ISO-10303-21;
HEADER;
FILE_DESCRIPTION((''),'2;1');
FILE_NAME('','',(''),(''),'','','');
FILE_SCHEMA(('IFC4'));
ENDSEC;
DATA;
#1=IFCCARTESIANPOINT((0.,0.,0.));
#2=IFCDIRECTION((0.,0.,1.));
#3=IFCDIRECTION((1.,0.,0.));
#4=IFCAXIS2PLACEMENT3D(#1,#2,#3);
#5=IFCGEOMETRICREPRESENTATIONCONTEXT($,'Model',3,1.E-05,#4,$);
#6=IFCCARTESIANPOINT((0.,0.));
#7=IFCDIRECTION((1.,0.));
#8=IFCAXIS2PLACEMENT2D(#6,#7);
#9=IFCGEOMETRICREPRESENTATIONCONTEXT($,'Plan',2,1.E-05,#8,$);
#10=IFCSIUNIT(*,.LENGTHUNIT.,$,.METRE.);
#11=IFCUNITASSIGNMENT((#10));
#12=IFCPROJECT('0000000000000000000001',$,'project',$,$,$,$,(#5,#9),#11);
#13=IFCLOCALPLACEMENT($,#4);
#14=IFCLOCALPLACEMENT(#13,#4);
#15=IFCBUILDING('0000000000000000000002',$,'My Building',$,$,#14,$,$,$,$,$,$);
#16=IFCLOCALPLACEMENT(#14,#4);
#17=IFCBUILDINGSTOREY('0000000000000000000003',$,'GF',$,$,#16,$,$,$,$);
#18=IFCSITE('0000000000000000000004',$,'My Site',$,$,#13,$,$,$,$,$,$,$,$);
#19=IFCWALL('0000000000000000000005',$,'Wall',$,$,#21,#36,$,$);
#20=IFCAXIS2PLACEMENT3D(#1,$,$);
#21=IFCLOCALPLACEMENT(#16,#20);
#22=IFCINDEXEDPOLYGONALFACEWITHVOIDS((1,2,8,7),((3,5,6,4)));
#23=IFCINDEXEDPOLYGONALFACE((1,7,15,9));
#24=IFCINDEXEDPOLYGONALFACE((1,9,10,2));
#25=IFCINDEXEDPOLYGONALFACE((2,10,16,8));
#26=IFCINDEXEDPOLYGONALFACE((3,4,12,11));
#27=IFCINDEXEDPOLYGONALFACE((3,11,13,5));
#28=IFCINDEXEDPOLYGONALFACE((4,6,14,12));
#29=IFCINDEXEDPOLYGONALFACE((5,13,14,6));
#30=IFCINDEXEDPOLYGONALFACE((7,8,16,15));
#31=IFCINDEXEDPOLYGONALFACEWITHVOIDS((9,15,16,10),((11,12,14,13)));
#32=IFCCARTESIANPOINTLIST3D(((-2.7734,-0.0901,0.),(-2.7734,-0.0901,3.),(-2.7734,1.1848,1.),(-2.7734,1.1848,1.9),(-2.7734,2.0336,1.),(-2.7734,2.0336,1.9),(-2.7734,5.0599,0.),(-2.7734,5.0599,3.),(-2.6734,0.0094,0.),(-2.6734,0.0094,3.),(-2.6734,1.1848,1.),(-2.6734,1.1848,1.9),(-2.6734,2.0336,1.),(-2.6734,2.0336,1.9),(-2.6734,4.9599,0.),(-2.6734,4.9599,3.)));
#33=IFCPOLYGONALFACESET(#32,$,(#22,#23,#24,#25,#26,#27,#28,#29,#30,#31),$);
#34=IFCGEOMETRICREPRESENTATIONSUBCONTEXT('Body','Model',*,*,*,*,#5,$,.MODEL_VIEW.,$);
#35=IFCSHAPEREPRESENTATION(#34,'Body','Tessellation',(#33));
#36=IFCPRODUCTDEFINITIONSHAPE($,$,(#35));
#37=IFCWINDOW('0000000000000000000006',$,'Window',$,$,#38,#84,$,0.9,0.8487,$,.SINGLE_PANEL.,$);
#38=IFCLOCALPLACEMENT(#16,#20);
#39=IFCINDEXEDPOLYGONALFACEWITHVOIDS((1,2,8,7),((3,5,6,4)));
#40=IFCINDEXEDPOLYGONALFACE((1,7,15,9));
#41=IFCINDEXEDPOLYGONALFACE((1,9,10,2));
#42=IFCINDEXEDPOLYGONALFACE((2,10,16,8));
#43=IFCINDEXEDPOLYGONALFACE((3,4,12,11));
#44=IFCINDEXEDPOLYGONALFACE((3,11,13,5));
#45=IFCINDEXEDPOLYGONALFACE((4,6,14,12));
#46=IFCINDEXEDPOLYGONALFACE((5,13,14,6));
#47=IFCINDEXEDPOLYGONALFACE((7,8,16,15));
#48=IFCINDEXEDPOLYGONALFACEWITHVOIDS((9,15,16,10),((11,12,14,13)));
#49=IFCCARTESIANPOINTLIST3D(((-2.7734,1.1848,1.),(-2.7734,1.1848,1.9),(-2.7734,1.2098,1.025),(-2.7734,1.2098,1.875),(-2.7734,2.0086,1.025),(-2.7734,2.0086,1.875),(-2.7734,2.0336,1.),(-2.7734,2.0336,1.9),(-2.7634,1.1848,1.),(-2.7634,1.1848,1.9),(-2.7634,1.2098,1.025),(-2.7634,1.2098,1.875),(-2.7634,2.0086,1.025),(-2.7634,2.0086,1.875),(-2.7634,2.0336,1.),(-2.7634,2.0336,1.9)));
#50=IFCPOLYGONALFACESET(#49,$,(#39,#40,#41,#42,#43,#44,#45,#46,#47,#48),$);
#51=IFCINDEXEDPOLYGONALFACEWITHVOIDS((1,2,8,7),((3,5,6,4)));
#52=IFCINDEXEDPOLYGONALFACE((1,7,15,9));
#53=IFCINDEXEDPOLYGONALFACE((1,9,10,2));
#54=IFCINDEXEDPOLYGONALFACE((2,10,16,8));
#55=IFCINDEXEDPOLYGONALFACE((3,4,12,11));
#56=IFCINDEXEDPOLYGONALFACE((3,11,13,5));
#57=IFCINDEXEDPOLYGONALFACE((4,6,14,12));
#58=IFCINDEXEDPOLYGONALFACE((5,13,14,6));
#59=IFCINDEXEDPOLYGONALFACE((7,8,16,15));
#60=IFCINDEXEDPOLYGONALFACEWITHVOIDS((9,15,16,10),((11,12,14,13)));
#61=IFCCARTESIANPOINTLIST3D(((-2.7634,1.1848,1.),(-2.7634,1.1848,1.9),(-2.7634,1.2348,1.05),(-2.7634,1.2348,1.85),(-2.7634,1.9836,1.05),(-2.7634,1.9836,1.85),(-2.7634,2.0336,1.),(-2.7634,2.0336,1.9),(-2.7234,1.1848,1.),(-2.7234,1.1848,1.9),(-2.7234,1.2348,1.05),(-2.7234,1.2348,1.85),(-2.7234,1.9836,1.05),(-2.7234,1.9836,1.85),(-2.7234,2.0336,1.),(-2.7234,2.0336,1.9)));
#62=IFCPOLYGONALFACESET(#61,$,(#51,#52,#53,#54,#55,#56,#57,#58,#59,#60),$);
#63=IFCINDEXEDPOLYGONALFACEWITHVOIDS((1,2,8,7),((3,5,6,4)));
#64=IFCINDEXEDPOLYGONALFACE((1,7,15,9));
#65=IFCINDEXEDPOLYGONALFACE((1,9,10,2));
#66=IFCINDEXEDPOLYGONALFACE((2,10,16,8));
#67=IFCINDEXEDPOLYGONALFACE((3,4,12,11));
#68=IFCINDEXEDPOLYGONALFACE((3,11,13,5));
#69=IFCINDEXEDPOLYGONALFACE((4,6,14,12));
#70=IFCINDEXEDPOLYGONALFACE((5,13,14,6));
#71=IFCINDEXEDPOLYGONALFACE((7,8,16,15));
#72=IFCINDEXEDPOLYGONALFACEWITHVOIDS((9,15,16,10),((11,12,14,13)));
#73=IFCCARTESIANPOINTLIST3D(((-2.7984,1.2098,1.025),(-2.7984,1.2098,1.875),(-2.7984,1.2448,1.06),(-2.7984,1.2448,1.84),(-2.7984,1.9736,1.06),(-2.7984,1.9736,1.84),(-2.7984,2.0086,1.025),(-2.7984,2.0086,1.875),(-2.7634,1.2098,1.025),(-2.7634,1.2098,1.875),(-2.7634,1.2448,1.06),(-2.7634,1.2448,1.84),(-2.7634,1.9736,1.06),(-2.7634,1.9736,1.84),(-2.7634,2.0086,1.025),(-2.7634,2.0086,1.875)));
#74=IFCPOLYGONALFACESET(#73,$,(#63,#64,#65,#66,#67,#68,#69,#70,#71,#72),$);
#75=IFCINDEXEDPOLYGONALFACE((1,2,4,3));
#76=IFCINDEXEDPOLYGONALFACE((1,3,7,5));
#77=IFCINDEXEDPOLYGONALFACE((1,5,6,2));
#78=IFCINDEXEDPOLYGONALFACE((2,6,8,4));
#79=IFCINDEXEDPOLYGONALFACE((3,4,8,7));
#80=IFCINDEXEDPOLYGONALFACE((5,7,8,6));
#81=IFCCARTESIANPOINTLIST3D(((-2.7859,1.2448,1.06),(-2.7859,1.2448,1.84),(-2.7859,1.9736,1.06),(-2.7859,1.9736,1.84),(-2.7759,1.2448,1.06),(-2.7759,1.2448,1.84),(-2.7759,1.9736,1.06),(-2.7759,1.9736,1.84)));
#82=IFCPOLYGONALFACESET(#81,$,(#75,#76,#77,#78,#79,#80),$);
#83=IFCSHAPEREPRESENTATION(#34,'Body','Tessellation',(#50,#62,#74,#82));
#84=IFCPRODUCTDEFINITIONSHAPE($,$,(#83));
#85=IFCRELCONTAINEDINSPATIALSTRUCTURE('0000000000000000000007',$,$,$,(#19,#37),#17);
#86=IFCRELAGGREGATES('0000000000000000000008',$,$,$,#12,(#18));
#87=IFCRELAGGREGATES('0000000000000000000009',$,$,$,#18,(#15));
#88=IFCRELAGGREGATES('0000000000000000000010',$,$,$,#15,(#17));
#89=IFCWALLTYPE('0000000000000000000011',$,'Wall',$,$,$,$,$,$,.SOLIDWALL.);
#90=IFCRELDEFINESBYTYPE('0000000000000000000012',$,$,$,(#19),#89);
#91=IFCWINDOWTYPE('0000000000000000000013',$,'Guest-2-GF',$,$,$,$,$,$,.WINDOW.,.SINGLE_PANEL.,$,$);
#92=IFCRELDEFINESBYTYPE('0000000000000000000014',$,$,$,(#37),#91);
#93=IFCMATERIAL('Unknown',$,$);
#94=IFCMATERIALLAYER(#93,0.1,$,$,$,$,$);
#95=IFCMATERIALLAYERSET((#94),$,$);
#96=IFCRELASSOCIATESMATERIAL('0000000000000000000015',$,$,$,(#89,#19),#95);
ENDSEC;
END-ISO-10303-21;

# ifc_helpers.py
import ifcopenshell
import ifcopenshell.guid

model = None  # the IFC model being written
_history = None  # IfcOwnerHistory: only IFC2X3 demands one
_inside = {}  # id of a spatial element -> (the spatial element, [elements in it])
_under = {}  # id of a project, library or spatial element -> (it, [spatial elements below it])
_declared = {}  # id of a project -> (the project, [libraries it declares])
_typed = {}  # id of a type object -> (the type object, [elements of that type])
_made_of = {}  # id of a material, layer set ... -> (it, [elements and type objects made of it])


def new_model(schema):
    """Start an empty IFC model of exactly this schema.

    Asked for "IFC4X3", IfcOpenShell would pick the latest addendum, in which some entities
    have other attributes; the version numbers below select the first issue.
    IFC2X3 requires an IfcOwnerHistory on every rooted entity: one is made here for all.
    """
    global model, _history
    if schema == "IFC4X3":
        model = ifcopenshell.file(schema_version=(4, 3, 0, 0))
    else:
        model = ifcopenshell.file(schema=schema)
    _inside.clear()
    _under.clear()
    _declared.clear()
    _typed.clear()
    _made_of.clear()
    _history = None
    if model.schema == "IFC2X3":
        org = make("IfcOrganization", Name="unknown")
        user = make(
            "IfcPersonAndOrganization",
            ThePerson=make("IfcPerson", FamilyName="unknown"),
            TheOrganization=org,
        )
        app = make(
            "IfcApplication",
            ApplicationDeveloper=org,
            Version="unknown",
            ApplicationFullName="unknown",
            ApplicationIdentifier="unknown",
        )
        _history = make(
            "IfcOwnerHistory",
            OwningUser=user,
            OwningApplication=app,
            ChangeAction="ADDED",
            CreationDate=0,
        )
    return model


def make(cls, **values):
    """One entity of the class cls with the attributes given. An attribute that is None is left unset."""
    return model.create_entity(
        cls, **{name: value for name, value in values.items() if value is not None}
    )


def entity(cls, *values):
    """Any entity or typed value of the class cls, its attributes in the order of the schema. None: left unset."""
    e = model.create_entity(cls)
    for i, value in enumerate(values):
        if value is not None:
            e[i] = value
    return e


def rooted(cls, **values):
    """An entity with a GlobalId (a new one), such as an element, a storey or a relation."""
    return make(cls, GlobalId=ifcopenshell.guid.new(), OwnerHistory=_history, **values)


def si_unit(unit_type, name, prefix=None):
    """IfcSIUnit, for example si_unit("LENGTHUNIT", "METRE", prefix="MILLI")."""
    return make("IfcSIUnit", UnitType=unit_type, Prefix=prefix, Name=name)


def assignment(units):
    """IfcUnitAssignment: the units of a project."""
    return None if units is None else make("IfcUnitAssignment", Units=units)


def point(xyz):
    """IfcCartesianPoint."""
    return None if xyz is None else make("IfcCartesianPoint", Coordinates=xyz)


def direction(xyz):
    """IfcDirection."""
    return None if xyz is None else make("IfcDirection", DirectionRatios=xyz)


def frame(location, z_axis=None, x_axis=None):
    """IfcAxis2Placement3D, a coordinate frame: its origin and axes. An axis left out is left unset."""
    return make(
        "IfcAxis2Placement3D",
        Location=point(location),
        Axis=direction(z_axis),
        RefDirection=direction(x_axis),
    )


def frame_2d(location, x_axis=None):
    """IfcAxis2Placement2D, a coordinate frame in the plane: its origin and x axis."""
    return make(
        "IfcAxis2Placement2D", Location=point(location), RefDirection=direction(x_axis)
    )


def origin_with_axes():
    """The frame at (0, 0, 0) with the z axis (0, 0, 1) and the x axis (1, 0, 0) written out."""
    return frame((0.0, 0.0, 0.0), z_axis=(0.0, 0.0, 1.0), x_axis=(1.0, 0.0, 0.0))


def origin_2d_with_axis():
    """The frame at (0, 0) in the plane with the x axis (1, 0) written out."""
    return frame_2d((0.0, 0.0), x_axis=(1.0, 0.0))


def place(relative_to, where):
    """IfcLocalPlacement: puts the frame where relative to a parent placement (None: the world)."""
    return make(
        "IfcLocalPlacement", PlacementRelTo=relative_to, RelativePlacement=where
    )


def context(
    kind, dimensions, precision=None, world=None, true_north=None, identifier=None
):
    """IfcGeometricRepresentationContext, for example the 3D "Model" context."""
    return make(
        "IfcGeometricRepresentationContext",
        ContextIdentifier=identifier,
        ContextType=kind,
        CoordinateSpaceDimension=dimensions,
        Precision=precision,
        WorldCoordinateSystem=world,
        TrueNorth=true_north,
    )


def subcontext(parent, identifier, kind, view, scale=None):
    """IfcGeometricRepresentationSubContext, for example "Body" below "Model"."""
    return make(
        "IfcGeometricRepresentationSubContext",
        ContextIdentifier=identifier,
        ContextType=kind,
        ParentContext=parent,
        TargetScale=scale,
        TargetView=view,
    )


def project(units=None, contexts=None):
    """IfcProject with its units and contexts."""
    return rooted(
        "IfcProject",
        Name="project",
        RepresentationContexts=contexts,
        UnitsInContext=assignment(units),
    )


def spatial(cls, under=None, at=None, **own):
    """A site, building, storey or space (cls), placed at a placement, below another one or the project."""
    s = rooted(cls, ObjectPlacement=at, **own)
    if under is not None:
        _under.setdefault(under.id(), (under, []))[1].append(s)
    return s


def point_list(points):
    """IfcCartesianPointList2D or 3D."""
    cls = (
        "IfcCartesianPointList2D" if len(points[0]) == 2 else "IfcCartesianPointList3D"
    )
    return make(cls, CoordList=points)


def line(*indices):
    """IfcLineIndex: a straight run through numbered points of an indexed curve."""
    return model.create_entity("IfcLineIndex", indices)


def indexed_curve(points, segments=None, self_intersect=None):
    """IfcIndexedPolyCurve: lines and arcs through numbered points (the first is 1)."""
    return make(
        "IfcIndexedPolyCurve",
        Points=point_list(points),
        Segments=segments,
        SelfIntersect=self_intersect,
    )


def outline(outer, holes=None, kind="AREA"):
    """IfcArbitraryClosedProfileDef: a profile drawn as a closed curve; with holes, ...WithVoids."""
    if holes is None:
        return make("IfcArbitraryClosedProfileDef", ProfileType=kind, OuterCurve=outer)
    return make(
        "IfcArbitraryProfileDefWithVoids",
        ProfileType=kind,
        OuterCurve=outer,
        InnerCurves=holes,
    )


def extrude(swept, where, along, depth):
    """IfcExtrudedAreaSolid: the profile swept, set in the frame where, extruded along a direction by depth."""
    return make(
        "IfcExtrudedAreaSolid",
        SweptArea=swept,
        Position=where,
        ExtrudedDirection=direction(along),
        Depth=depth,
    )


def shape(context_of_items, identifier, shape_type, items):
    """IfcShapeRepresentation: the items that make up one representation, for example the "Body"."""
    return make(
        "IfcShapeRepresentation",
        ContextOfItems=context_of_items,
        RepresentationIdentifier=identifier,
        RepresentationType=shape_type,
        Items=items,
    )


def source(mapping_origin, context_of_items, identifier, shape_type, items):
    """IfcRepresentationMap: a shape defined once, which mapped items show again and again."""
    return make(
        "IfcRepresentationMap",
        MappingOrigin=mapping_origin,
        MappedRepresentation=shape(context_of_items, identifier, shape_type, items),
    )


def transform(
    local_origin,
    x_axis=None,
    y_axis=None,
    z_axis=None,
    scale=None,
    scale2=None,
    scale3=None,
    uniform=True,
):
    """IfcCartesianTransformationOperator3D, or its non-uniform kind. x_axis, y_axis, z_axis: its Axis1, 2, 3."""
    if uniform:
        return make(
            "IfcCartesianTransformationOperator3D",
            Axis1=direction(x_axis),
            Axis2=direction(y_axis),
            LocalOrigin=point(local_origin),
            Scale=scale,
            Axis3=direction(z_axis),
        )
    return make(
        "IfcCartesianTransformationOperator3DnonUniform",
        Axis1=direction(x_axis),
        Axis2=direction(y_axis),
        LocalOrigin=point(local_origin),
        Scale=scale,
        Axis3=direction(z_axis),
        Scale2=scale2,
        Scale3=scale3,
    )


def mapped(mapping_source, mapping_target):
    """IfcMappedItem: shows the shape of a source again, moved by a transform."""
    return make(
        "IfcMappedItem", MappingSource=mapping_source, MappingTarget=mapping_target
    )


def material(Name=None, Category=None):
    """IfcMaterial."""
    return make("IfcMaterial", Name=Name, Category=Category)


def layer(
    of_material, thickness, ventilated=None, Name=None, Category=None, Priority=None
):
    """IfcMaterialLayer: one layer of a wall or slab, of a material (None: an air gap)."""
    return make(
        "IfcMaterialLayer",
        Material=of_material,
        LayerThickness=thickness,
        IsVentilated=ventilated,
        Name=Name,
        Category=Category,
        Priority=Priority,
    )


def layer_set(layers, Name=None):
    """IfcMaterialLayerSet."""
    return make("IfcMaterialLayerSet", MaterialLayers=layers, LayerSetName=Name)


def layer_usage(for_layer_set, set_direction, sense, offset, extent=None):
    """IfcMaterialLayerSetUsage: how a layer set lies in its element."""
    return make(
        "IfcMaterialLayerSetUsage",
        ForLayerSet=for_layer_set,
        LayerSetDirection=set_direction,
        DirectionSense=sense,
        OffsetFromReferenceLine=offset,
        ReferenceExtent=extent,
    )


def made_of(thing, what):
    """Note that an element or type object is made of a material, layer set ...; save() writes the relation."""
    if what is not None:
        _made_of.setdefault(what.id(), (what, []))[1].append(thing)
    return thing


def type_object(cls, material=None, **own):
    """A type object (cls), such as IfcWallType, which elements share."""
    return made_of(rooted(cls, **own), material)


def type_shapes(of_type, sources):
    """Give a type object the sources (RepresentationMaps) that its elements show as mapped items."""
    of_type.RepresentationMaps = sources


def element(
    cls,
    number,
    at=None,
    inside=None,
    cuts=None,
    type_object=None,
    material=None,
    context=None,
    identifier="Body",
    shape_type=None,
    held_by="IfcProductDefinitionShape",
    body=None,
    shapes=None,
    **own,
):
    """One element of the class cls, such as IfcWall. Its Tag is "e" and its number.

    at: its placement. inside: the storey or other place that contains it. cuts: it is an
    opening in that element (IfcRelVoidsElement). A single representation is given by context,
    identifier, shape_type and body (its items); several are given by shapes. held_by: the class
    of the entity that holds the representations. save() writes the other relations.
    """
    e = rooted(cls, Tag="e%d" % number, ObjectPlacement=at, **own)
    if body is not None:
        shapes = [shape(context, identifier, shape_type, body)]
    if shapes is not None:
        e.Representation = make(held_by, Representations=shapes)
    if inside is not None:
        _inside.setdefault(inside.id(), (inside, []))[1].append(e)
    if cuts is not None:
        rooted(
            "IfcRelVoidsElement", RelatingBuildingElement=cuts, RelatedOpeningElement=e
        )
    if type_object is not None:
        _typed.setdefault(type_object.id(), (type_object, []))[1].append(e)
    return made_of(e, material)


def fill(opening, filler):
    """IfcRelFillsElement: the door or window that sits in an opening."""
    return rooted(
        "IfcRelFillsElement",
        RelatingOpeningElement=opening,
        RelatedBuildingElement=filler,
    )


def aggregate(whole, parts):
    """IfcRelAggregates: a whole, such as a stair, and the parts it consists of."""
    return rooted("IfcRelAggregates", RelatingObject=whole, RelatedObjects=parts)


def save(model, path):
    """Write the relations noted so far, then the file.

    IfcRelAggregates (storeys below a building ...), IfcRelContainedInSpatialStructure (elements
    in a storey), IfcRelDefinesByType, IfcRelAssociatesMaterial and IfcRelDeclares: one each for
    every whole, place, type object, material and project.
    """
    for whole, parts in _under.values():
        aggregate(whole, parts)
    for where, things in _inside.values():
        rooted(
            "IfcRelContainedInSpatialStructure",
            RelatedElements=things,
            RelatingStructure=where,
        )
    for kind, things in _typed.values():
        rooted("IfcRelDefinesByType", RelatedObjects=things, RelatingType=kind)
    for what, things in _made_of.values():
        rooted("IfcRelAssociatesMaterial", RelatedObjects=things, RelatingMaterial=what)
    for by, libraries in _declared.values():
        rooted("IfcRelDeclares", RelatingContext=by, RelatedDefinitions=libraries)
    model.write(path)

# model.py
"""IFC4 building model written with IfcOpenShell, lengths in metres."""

from ifc_helpers import new_model, entity, si_unit, frame, origin_with_axes, origin_2d_with_axis, place, context, subcontext, project, spatial, line, indexed_curve, outline, extrude, shape, source, transform, mapped, material, layer, layer_set, layer_usage, type_object, type_shapes, element, fill, save


model = new_model("IFC4")

# Units and contexts
model_context = context("Model", 3, precision=1e-05, world=origin_with_axes())
plan_context = context("Plan", 2, precision=1e-05, world=origin_2d_with_axis())
body_context_1 = subcontext(model_context, "Body", "Model", "MODEL_VIEW")
body_context_2 = subcontext(plan_context, "Body", "Plan", "PLAN_VIEW")
ifc_project = project(units=[si_unit("LENGTHUNIT", "METRE")], contexts=[model_context, plan_context])

# Site, building, storey
site_placement = place(None, origin_with_axes())
site = spatial("IfcSite", under=ifc_project, at=site_placement, Name="My Site")
building_placement = place(site_placement, origin_with_axes())
building = spatial("IfcBuilding", under=site, at=building_placement, Name="My Building")
storey_placement = place(building_placement, origin_with_axes())
storey = spatial("IfcBuildingStorey", under=building, at=storey_placement, Name="GF")

# Shared definitions
ifc_material_1 = material(Name="Unknown")

# Shared definitions
ifc_layer_1 = layer(ifc_material_1, 0.1)
ifc_layer_set_1 = layer_set([ifc_layer_1])
wall_type = type_object("IfcWallType", Name="Wall", PredefinedType="SOLIDWALL", material=ifc_layer_set_1)

# Wall, opening, window
ifc_layer_usage_1 = layer_usage(ifc_layer_set_1, "AXIS2", "POSITIVE", 0.0)
wall_1_placement = place(storey_placement, frame((-2.7734, 5.0599, 0.0), z_axis=(0.0, 0.0, 1.0), x_axis=(0.0, -1.0, 0.0)))
wall_1 = element("IfcWall", 1, at=wall_1_placement, inside=storey, type_object=wall_type, material=ifc_layer_usage_1, Name="Wall", context=body_context_1, shape_type="SweptSolid", body=[
    extrude(outline(indexed_curve([(0.0, 0.0), (0.1, 0.1), (5.0504, 0.1), (5.15, 0.0)], segments=[line(1, 2, 3, 4, 1)])), origin_with_axes(), (0.0, 0.0, 1.0), 3.0),
])
shared_shape_1 = source(origin_with_axes(), body_context_1, "Body", "SweptSolid", [
    extrude(outline(indexed_curve([(0.0, 0.0), (0.8487, 0.0), (0.8487, 0.9), (0.0, 0.9)], segments=[line(1, 2, 3, 4, 1)])), frame((0.0, -0.6, 0.0), z_axis=(0.0, -1.0, 0.0), x_axis=(1.0, 0.0, 0.0)), (0.0, 0.0, -1.0), 1.2),
])
opening_1_placement = place(wall_1_placement, frame((3.875, 0.1, 1.0), z_axis=(0.0, 0.0, 1.0), x_axis=(-1.0, 0.0, 0.0)))
opening_1 = element("IfcOpeningElement", 2, at=opening_1_placement, cuts=wall_1, PredefinedType="OPENING", context=body_context_1, shape_type="MappedRepresentation", body=[
    mapped(shared_shape_1, transform((0.0, 0.0, 0.0), x_axis=(1.0, 0.0, 0.0), y_axis=(0.0, 1.0, 0.0), z_axis=(0.0, 0.0, 1.0), scale=1.0)),
])
window_type_1 = type_object("IfcWindowType", Name="Guest-2-GF", PartitioningType="SINGLE_PANEL", PredefinedType="WINDOW")
shared_shape_2 = source(origin_with_axes(), body_context_1, "Body", "SweptSolid", [
    extrude(outline(indexed_curve([(0.0, 0.0), (0.8487, 0.0), (0.8487, 0.9), (0.0, 0.9)], segments=[line(1, 2, 3, 4, 1)]), holes=[indexed_curve([(0.025, 0.025), (0.8237, 0.025), (0.8237, 0.875), (0.025, 0.875)], segments=[line(1, 2, 3, 4, 1)])]), frame((0.0, 0.09, 0.0), z_axis=(0.0, -1.0, 0.0), x_axis=(1.0, 0.0, 0.0)), (0.0, 0.0, -1.0), 0.01),
    extrude(outline(indexed_curve([(0.0, 0.0), (0.8487, 0.0), (0.8487, 0.9), (0.0, 0.9)], segments=[line(1, 2, 3, 4, 1)]), holes=[indexed_curve([(0.05, 0.05), (0.7987, 0.05), (0.7987, 0.85), (0.05, 0.85)], segments=[line(1, 2, 3, 4, 1)])]), frame((0.0, 0.05, 0.0), z_axis=(0.0, -1.0, 0.0), x_axis=(1.0, 0.0, 0.0)), (0.0, 0.0, -1.0), 0.04),
    extrude(outline(indexed_curve([(0.0, 0.0), (0.7987, 0.0), (0.7987, 0.85), (0.0, 0.85)], segments=[line(1, 2, 3, 4, 1)]), holes=[indexed_curve([(0.035, 0.035), (0.7637, 0.035), (0.7637, 0.815), (0.035, 0.815)], segments=[line(1, 2, 3, 4, 1)])]), frame((0.025, 0.09, 0.025), z_axis=(0.0, -1.0, 0.0), x_axis=(1.0, 0.0, 0.0)), (0.0, 0.0, -1.0), 0.035),
    extrude(outline(indexed_curve([(0.035, 0.035), (0.7637, 0.035), (0.7637, 0.815), (0.035, 0.815)], segments=[line(1, 2, 3, 4, 1)])), frame((0.025, 0.1025, 0.025), z_axis=(0.0, -1.0, 0.0), x_axis=(1.0, 0.0, 0.0)), (0.0, 0.0, -1.0), 0.01),
])
shared_shape_3 = source(origin_with_axes(), body_context_2, "Body", "Curve2D", [
    entity("IfcIndexedPolyCurve", entity("IfcCartesianPointList2D", [[0.05, 0.05], [0.7987, 0.05]])),
    entity("IfcIndexedPolyCurve", entity("IfcCartesianPointList2D", [[0.0, 0.1], [0.025, 0.1], [0.025, 0.09], [0.05, 0.09], [0.05, 0.05], [0.0, 0.05]]), [entity("IfcLineIndex", [1, 2, 3, 4, 5, 6, 1])]),
    entity("IfcIndexedPolyCurve", entity("IfcCartesianPointList2D", [[0.8487, 0.1], [0.8237, 0.1], [0.8237, 0.09], [0.7987, 0.09], [0.7987, 0.05], [0.8487, 0.05]]), [entity("IfcLineIndex", [1, 2, 3, 4, 5, 6, 1])]),
    entity("IfcIndexedPolyCurve", entity("IfcCartesianPointList2D", [[0.025, 0.09], [0.06, 0.09], [0.06, 0.125], [0.025, 0.125]]), [entity("IfcLineIndex", [1, 2, 3, 4, 1])]),
    entity("IfcIndexedPolyCurve", entity("IfcCartesianPointList2D", [[0.8237, 0.09], [0.7887, 0.09], [0.7887, 0.125], [0.8237, 0.125]]), [entity("IfcLineIndex", [1, 2, 3, 4, 1])]),
    entity("IfcIndexedPolyCurve", entity("IfcCartesianPointList2D", [[0.06, 0.09], [0.7887, 0.09]])),
    entity("IfcIndexedPolyCurve", entity("IfcCartesianPointList2D", [[0.06, 0.125], [0.7887, 0.125]])),
    entity("IfcIndexedPolyCurve", entity("IfcCartesianPointList2D", [[0.06, 0.1075], [0.7887, 0.1075]])),
])
type_shapes(window_type_1, [shared_shape_2, shared_shape_3])
window_1_placement = place(opening_1_placement, frame((0.0, 0.0, 0.0), z_axis=(0.0, 0.0, 1.0), x_axis=(1.0, 0.0, 0.0)))
window_1 = element("IfcWindow", 3, at=window_1_placement, inside=storey, type_object=window_type_1, Name="Window", OverallHeight=0.9, OverallWidth=0.8487, PartitioningType="SINGLE_PANEL", shapes=[
    shape(body_context_1, "Body", "MappedRepresentation", [mapped(shared_shape_2, transform((0.0, 0.0, 0.0), x_axis=(1.0, 0.0, 0.0), y_axis=(0.0, 1.0, 0.0), z_axis=(0.0, 0.0, 1.0), scale=1.0))]),
    shape(body_context_2, "Body", "MappedRepresentation", [mapped(shared_shape_3, transform((0.0, 0.0, 0.0), x_axis=(1.0, 0.0, 0.0), y_axis=(0.0, 1.0, 0.0), z_axis=(0.0, 0.0, 1.0), scale=1.0))]),
])
fill(opening_1, window_1)

save(model, "model.ifc")
